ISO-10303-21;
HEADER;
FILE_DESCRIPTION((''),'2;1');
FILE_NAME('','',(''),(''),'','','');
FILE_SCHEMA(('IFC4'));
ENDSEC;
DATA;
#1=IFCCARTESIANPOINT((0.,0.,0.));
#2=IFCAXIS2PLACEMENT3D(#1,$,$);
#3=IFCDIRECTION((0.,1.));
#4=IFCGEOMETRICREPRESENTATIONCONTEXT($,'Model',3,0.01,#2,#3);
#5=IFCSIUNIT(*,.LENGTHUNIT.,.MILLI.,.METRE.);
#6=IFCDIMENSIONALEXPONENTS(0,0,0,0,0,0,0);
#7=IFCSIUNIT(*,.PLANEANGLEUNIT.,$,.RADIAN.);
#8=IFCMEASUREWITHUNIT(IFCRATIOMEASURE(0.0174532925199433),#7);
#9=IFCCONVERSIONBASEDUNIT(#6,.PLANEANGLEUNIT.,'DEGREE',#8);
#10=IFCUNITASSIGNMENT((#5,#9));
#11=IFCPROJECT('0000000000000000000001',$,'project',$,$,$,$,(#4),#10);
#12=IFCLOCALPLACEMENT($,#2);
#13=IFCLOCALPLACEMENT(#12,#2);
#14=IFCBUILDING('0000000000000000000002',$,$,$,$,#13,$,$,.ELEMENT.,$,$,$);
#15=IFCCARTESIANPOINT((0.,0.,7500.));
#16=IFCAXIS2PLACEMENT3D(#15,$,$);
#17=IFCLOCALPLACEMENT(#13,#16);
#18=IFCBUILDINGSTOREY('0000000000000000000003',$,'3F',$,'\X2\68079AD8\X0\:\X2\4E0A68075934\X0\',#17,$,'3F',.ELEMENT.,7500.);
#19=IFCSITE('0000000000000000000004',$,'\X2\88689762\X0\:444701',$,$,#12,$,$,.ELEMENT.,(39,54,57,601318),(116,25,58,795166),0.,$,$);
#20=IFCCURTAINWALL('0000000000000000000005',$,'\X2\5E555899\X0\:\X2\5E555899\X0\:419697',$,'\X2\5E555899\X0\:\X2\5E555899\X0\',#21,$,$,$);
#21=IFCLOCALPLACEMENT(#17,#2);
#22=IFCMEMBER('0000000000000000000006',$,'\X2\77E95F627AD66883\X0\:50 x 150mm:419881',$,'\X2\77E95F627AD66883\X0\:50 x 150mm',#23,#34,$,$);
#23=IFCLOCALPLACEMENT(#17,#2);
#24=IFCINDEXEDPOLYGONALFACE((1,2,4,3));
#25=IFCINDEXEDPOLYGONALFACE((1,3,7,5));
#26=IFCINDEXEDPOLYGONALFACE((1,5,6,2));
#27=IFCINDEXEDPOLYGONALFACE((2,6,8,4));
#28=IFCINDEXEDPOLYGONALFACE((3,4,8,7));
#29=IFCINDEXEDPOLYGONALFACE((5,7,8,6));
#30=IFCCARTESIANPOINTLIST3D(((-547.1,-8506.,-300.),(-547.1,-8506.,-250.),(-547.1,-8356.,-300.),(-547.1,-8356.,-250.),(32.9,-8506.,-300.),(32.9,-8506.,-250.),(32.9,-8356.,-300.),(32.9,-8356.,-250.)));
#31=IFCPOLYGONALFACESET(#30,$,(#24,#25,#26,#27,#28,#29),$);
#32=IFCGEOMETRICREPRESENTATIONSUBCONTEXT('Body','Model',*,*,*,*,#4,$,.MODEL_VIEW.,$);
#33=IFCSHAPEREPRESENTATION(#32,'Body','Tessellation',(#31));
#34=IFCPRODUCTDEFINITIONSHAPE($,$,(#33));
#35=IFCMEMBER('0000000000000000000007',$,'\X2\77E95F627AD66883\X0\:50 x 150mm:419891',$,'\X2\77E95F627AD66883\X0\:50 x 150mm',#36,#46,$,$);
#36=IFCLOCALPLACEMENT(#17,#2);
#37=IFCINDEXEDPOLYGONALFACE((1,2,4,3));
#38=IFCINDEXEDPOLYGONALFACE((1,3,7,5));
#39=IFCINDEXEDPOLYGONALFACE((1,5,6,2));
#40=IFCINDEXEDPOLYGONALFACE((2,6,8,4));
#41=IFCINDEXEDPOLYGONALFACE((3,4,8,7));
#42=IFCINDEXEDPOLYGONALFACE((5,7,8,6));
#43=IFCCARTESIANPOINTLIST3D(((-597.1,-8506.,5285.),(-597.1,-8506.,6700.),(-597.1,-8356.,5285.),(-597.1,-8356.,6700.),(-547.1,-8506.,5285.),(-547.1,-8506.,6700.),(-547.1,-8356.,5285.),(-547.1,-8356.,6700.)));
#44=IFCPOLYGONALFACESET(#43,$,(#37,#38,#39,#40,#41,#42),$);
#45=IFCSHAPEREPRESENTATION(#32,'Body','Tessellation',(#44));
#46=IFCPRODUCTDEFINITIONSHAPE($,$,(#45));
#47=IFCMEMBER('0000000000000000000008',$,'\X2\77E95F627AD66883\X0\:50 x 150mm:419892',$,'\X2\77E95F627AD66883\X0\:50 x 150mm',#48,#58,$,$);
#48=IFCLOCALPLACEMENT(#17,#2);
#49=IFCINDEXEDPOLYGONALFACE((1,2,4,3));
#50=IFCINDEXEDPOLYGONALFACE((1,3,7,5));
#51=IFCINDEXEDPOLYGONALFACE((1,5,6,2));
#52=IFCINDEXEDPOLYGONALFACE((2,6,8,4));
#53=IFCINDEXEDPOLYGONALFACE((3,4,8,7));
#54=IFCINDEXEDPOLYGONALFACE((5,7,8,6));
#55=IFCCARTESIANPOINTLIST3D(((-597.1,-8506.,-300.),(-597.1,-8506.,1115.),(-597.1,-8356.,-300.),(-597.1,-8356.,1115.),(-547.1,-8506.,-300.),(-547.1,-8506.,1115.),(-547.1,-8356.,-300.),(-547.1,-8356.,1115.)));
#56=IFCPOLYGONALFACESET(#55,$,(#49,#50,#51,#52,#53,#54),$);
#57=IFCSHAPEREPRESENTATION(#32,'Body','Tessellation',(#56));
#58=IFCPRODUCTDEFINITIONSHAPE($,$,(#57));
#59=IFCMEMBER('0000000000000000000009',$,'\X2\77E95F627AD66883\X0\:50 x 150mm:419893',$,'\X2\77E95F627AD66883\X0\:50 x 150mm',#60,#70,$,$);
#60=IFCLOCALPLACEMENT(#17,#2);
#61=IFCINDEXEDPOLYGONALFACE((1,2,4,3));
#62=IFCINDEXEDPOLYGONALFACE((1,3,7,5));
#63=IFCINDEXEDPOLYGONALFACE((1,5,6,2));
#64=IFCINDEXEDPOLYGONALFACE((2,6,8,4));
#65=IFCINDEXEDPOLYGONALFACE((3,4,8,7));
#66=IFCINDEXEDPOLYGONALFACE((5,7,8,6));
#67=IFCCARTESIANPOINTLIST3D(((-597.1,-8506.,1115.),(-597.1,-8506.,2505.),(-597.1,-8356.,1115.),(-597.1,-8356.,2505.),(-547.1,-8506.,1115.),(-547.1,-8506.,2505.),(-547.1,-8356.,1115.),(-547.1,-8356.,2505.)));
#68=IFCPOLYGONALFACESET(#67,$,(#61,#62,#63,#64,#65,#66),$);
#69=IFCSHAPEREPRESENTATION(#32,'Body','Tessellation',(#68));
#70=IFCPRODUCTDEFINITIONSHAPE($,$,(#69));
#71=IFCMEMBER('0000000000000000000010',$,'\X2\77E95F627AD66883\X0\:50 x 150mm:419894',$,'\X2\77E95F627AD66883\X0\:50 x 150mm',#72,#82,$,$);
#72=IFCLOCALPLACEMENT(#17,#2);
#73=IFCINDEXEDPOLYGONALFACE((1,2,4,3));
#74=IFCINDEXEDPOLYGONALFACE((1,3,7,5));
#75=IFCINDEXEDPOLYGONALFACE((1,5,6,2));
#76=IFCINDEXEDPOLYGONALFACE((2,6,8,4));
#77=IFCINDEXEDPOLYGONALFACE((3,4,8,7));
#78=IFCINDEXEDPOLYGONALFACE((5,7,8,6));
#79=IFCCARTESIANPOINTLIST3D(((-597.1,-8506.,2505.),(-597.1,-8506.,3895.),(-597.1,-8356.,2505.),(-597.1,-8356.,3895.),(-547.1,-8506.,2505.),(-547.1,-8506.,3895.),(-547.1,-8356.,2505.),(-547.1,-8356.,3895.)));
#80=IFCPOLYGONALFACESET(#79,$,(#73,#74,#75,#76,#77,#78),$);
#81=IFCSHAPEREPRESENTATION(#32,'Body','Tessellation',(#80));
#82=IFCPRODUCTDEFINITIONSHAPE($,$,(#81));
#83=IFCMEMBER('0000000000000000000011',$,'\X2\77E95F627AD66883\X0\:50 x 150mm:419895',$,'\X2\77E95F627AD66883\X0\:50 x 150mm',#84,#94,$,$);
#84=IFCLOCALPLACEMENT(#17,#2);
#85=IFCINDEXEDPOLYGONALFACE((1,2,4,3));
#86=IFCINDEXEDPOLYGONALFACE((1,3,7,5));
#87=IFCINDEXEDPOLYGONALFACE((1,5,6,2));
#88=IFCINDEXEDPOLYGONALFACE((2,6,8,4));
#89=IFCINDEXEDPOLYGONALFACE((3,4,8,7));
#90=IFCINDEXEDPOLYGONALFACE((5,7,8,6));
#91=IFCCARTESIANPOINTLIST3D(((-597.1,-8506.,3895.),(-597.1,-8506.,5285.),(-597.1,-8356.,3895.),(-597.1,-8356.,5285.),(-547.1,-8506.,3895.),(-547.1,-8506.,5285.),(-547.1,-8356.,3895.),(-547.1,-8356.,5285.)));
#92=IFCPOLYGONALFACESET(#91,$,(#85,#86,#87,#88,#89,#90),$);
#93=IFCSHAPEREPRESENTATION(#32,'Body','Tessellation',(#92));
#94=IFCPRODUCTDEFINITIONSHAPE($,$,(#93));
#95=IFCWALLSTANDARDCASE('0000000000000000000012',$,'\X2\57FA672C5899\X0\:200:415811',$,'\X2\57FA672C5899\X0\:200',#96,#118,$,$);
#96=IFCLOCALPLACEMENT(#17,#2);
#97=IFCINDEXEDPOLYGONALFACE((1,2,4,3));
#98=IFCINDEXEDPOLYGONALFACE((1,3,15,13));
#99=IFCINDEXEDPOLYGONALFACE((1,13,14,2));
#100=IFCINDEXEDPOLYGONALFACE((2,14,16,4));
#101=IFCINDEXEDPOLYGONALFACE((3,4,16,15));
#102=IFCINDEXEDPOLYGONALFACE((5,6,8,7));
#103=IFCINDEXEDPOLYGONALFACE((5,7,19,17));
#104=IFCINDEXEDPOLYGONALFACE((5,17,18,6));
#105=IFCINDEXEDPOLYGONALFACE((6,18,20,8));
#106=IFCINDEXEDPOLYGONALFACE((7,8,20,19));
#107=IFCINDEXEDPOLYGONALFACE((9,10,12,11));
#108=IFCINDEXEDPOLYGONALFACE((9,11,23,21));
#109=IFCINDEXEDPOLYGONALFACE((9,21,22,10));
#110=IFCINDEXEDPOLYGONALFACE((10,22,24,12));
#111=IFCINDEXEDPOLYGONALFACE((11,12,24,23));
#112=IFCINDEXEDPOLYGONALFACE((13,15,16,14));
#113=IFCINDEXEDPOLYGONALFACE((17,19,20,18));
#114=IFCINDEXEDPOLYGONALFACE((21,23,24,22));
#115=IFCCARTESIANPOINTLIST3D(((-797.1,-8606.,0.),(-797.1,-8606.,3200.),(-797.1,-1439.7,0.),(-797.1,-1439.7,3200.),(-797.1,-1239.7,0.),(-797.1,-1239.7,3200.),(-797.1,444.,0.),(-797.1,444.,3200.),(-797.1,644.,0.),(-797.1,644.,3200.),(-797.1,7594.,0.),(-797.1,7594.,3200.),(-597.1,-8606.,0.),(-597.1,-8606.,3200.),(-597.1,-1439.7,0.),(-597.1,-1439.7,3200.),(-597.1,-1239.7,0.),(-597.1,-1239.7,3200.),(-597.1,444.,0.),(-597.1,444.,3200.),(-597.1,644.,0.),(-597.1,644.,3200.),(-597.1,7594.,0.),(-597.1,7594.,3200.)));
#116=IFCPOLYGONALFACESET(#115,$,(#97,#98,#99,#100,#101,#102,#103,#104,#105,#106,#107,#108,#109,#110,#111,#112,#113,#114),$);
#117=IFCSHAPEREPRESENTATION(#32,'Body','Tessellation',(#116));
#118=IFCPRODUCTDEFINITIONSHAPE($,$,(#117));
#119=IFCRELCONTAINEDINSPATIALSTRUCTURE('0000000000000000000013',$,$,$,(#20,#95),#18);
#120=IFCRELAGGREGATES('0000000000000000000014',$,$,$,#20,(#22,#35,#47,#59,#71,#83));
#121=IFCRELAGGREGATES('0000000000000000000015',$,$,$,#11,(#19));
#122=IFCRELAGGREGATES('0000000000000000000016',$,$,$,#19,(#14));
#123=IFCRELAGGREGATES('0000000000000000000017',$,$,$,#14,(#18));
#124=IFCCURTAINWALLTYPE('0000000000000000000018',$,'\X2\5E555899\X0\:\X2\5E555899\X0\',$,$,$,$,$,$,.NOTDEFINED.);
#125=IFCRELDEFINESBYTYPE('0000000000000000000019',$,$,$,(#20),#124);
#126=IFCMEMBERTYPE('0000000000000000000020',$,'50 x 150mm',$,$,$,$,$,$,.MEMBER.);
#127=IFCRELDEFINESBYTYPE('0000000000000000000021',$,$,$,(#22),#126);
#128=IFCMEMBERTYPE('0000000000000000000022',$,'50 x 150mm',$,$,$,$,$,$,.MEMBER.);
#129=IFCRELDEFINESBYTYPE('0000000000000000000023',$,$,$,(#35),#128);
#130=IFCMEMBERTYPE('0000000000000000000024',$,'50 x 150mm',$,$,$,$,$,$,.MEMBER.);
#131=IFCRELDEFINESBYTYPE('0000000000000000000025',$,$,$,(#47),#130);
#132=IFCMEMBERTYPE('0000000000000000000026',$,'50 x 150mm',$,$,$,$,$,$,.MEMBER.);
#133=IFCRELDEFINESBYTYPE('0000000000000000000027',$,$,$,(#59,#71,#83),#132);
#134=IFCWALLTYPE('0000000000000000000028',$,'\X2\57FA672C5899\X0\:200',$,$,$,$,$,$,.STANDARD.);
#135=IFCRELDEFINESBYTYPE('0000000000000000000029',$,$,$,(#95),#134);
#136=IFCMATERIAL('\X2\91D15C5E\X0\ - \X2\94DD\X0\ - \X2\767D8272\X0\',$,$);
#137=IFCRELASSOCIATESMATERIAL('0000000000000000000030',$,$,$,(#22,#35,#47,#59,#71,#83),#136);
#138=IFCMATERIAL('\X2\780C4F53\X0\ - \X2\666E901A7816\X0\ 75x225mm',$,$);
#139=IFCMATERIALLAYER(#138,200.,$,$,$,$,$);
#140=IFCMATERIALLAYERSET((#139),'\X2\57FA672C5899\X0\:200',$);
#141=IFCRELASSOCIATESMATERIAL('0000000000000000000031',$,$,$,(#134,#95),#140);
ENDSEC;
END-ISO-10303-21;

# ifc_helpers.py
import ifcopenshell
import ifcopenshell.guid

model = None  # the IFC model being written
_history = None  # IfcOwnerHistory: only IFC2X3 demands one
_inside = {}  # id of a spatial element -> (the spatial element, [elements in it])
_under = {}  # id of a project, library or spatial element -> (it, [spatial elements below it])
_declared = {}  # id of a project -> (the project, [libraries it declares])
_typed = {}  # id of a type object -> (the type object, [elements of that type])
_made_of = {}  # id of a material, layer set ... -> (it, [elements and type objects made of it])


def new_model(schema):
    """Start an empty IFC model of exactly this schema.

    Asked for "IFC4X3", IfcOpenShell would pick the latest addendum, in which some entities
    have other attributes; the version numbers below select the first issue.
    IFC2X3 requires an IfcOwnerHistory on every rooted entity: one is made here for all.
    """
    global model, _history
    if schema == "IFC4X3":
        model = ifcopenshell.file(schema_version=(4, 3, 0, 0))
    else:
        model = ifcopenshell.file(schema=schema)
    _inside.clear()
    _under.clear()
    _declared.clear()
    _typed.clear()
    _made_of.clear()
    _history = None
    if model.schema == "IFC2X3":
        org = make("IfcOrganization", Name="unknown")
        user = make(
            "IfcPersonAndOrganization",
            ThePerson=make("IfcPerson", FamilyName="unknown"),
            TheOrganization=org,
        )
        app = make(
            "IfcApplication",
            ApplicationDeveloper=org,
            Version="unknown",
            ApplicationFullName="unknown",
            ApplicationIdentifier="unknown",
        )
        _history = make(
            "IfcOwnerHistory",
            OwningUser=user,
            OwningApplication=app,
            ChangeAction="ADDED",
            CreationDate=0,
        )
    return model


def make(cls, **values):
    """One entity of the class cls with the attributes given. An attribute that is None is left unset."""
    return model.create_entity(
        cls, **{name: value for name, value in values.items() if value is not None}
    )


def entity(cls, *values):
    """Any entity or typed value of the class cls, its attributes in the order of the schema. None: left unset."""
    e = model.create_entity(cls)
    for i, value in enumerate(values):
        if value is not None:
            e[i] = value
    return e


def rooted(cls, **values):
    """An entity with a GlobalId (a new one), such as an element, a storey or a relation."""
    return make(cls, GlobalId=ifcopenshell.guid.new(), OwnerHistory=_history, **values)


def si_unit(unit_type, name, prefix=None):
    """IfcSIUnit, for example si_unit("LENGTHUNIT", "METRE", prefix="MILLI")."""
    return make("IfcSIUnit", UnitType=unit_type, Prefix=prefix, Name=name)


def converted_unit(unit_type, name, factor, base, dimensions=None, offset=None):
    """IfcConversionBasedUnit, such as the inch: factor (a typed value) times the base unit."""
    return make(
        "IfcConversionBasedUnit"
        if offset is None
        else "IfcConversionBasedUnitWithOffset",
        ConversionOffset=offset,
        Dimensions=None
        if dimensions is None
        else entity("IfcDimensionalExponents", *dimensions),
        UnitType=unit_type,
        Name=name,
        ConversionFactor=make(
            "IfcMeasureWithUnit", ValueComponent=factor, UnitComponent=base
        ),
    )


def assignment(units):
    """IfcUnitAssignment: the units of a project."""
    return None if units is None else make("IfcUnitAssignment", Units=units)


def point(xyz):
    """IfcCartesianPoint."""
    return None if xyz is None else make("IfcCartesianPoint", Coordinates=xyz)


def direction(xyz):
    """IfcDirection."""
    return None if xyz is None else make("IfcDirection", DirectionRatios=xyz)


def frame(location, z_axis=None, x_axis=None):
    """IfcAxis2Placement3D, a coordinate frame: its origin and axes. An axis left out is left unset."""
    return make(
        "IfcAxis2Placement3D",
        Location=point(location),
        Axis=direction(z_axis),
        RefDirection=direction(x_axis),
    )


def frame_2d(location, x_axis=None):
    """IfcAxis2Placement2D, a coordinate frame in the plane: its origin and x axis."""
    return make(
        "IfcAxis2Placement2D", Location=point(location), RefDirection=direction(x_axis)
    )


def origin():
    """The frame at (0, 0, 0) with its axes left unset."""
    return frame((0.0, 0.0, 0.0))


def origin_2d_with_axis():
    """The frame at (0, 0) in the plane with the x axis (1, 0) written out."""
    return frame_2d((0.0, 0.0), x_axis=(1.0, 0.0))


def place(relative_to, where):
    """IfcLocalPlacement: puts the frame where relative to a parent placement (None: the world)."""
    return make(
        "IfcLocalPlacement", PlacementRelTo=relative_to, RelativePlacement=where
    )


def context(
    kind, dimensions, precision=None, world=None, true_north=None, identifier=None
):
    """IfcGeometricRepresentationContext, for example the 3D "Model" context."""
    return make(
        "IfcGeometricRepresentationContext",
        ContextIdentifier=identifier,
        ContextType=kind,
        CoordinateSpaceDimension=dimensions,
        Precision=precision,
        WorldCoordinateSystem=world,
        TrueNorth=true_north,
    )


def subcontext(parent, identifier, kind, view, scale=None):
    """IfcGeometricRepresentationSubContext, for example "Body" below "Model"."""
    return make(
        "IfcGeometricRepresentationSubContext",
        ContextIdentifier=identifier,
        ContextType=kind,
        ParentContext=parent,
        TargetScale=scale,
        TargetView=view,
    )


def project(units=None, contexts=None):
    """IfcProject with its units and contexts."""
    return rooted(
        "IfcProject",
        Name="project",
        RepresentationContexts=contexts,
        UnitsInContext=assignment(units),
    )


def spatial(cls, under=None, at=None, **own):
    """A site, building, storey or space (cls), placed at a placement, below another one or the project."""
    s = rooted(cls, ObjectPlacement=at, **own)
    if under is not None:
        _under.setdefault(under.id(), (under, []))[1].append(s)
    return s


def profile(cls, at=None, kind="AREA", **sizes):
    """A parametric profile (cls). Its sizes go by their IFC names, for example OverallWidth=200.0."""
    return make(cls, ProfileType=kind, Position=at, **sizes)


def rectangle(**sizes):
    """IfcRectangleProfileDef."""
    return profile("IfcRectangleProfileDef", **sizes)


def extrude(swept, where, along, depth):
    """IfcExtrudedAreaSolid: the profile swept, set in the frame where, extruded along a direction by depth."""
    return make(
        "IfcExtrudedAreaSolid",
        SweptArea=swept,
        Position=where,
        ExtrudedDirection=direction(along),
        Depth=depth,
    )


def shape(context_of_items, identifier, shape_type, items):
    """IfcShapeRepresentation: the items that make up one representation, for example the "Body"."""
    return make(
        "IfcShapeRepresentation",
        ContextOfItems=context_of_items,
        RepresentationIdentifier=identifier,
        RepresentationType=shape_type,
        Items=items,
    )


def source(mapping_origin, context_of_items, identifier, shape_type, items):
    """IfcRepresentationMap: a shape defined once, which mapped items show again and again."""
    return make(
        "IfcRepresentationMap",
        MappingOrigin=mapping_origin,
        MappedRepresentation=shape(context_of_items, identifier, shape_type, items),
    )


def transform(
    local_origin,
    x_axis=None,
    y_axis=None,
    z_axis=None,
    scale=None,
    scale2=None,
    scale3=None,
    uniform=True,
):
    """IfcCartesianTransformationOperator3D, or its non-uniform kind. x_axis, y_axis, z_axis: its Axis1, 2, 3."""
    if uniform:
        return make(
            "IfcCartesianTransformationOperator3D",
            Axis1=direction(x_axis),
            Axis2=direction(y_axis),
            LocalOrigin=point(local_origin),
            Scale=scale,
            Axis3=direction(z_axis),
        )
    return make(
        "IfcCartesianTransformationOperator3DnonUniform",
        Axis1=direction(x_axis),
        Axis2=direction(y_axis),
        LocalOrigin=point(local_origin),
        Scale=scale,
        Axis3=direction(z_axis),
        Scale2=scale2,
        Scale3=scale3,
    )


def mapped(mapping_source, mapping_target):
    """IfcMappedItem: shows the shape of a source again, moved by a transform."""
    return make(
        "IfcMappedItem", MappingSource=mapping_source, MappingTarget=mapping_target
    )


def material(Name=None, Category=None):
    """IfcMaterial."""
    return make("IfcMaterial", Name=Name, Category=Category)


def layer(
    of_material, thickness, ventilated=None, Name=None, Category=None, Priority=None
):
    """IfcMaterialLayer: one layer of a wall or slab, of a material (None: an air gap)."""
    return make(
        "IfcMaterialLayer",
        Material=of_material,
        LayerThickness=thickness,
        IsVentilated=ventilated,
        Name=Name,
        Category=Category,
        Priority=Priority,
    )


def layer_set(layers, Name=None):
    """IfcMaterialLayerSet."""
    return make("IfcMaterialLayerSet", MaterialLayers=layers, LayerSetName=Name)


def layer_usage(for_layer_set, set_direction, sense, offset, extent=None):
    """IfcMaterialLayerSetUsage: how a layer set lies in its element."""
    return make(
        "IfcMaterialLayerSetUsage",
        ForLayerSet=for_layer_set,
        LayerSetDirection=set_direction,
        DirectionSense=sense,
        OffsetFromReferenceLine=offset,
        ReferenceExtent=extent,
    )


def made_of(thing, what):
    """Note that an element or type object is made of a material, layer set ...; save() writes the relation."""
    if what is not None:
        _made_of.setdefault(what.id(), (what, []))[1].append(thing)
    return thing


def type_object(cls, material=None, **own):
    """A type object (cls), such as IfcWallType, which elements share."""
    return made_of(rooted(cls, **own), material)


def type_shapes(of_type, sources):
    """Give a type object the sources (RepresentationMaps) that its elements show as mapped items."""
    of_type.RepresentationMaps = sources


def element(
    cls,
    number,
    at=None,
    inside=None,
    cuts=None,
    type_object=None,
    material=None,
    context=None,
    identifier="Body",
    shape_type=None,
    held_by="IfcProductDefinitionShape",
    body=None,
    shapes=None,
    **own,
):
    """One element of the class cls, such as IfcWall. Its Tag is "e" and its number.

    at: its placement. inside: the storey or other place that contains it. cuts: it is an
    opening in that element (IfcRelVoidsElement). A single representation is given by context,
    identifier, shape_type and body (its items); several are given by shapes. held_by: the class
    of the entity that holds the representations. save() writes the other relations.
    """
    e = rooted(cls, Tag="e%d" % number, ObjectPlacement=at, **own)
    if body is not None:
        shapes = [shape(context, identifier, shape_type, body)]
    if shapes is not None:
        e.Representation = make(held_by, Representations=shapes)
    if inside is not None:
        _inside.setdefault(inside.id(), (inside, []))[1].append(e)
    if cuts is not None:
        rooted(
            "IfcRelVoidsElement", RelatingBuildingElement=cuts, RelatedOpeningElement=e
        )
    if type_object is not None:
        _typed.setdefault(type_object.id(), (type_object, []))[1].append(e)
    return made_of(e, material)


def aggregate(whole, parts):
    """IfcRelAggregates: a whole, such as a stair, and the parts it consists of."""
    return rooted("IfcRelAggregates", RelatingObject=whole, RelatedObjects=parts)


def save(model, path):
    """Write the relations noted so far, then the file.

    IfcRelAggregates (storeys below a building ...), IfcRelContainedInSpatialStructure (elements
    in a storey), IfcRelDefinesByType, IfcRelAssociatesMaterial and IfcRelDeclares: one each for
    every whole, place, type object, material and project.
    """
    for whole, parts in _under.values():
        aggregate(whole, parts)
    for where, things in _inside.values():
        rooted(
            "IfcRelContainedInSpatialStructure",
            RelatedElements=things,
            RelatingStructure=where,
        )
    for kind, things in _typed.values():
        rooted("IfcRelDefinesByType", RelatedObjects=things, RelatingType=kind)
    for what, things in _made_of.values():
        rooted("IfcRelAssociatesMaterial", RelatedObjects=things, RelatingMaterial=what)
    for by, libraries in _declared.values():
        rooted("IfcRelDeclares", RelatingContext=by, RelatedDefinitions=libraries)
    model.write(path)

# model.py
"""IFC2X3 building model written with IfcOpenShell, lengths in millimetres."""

from ifc_helpers import new_model, entity, si_unit, converted_unit, direction, frame, frame_2d, origin, origin_2d_with_axis, place, context, subcontext, project, spatial, rectangle, extrude, source, transform, mapped, material, layer, layer_set, layer_usage, type_object, type_shapes, element, aggregate, save


model = new_model("IFC2X3")

# Units and contexts
model_context = context("Model", 3, precision=0.01, world=origin(), true_north=direction((0.0, 1.0)))
body_context = subcontext(model_context, "Body", "Model", "MODEL_VIEW")
ifc_project = project(units=[si_unit("LENGTHUNIT", "METRE", prefix="MILLI"), converted_unit("PLANEANGLEUNIT", "DEGREE", entity("IfcRatioMeasure", 0.0174532925199433), si_unit("PLANEANGLEUNIT", "RADIAN"), dimensions=[0, 0, 0, 0, 0, 0, 0])], contexts=[model_context])

# Site, building, storey
site_placement = place(None, origin())
site = spatial("IfcSite", under=ifc_project, at=site_placement, Name="表面:444701", CompositionType="ELEMENT", RefLatitude=(39, 54, 57, 601318), RefLongitude=(116, 25, 58, 795166), RefElevation=0.0)
building_placement = place(site_placement, origin())
building = spatial("IfcBuilding", under=site, at=building_placement, CompositionType="ELEMENT")
storey_placement = place(building_placement, frame((0.0, 0.0, 7500.0)))
storey = spatial("IfcBuildingStorey", under=building, at=storey_placement, Name="3F", ObjectType="标高:上标头", LongName="3F", CompositionType="ELEMENT", Elevation=7500.0)

# Curtain wall, members
curtain_wall_type = type_object("IfcCurtainWallType", Name="幕墙:幕墙", PredefinedType="NOTDEFINED")
curtain_wall_placement = place(storey_placement, frame((0.0, 0.0, -7500.0)))
curtain_wall = element("IfcCurtainWall", 1, at=curtain_wall_placement, inside=storey, type_object=curtain_wall_type, Name="幕墙:幕墙:419697", ObjectType="幕墙:幕墙")
ifc_material_1 = material(Name="金属 - 铝 - 白色")
member_type_1 = type_object("IfcMemberType", Name="50 x 150mm", PredefinedType="MEMBER")
shared_shape_1 = source(origin(), body_context, "Body", "SweptSolid", [
    extrude(rectangle(XDim=150.0, YDim=50.0, at=origin_2d_with_axis()), frame((-25.0, 0.0, -580.0), z_axis=(0.0, 0.0, 1.0), x_axis=(0.0, -1.0, 0.0)), (0.0, 0.0, 1.0), 580.0),
])
type_shapes(member_type_1, [shared_shape_1])
member_1_placement = place(storey_placement, frame((-547.1, -8431.0, -300.0), z_axis=(-1.0, 0.0, 0.0), x_axis=(0.0, 0.0, -1.0)))
member_1 = element("IfcMember", 2, at=member_1_placement, type_object=member_type_1, material=ifc_material_1, Name="矩形竖梃:50 x 150mm:419881", ObjectType="矩形竖梃:50 x 150mm", context=body_context, shape_type="MappedRepresentation", body=[
    mapped(shared_shape_1, transform((0.0, 0.0, 0.0), scale=1.0)),
])
member_type_2 = type_object("IfcMemberType", Name="50 x 150mm", PredefinedType="MEMBER")
shared_shape_2 = source(origin(), body_context, "Body", "SweptSolid", [
    extrude(rectangle(XDim=150.0, YDim=50.0, at=origin_2d_with_axis()), frame((-25.0, 0.0, -1415.0), z_axis=(0.0, 0.0, 1.0), x_axis=(0.0, -1.0, 0.0)), (0.0, 0.0, 1.0), 1415.0),
])
type_shapes(member_type_2, [shared_shape_2])
member_2_placement = place(storey_placement, frame((-597.1, -8431.0, 6700.0), z_axis=(0.0, 0.0, 1.0), x_axis=(-1.0, 0.0, 0.0)))
member_2 = element("IfcMember", 3, at=member_2_placement, type_object=member_type_2, material=ifc_material_1, Name="矩形竖梃:50 x 150mm:419891", ObjectType="矩形竖梃:50 x 150mm", context=body_context, shape_type="MappedRepresentation", body=[
    mapped(shared_shape_2, transform((0.0, 0.0, 0.0), scale=1.0)),
])
member_type_3 = type_object("IfcMemberType", Name="50 x 150mm", PredefinedType="MEMBER")
shared_shape_3 = source(origin(), body_context, "Body", "SweptSolid", [
    extrude(rectangle(XDim=150.0, YDim=50.0, at=origin_2d_with_axis()), frame((-25.0, 0.0, -1415.0), z_axis=(0.0, 0.0, 1.0), x_axis=(0.0, -1.0, 0.0)), (0.0, 0.0, 1.0), 1415.0),
])
type_shapes(member_type_3, [shared_shape_3])
member_3_placement = place(storey_placement, frame((-597.1, -8431.0, 1115.0), z_axis=(0.0, 0.0, 1.0), x_axis=(-1.0, 0.0, 0.0)))
member_3 = element("IfcMember", 4, at=member_3_placement, type_object=member_type_3, material=ifc_material_1, Name="矩形竖梃:50 x 150mm:419892", ObjectType="矩形竖梃:50 x 150mm", context=body_context, shape_type="MappedRepresentation", body=[
    mapped(shared_shape_3, transform((0.0, 0.0, 0.0), scale=1.0)),
])
member_type_4 = type_object("IfcMemberType", Name="50 x 150mm", PredefinedType="MEMBER")
shared_shape_4 = source(origin(), body_context, "Body", "SweptSolid", [
    extrude(rectangle(XDim=150.0, YDim=50.0, at=origin_2d_with_axis()), frame((-25.0, 0.0, -1390.0), z_axis=(0.0, 0.0, 1.0), x_axis=(0.0, -1.0, 0.0)), (0.0, 0.0, 1.0), 1390.0),
])
type_shapes(member_type_4, [shared_shape_4])
member_4_placement = place(storey_placement, frame((-597.1, -8431.0, 2505.0), z_axis=(0.0, 0.0, 1.0), x_axis=(-1.0, 0.0, 0.0)))
member_4 = element("IfcMember", 5, at=member_4_placement, type_object=member_type_4, material=ifc_material_1, Name="矩形竖梃:50 x 150mm:419893", ObjectType="矩形竖梃:50 x 150mm", context=body_context, shape_type="MappedRepresentation", body=[
    mapped(shared_shape_4, transform((0.0, 0.0, 0.0), scale=1.0)),
])
member_5_placement = place(storey_placement, frame((-597.1, -8431.0, 3895.0), z_axis=(0.0, 0.0, 1.0), x_axis=(-1.0, 0.0, 0.0)))
member_5 = element("IfcMember", 6, at=member_5_placement, type_object=member_type_4, material=ifc_material_1, Name="矩形竖梃:50 x 150mm:419894", ObjectType="矩形竖梃:50 x 150mm", context=body_context, shape_type="MappedRepresentation", body=[
    mapped(shared_shape_4, transform((0.0, 0.0, 0.0), scale=1.0)),
])
member_6_placement = place(storey_placement, frame((-597.1, -8431.0, 5285.0), z_axis=(0.0, 0.0, 1.0), x_axis=(-1.0, 0.0, 0.0)))
member_6 = element("IfcMember", 7, at=member_6_placement, type_object=member_type_4, material=ifc_material_1, Name="矩形竖梃:50 x 150mm:419895", ObjectType="矩形竖梃:50 x 150mm", context=body_context, shape_type="MappedRepresentation", body=[
    mapped(shared_shape_4, transform((0.0, 0.0, 0.0), scale=1.0)),
])
aggregate(curtain_wall, [member_1, member_2, member_3, member_4, member_5, member_6])

# Shared definitions
ifc_material_2 = material(Name="砌体 - 普通砖 75x225mm")

# Wall, openings
ifc_layer_1 = layer(ifc_material_2, 200.0)
ifc_layer_set_1 = layer_set([ifc_layer_1], Name="基本墙:200")
ifc_layer_usage_1 = layer_usage(ifc_layer_set_1, "AXIS2", "NEGATIVE", 100.0)
wall_type_1 = type_object("IfcWallType", Name="基本墙:200", PredefinedType="STANDARD", material=ifc_layer_set_1)
wall_1_placement = place(storey_placement, frame((-697.1, -8606.0, 0.0), z_axis=(0.0, 0.0, 1.0), x_axis=(0.0, 1.0, 0.0)))
wall_1 = element("IfcWallStandardCase", 8, at=wall_1_placement, inside=storey, type_object=wall_type_1, material=ifc_layer_usage_1, Name="基本墙:200:415811", ObjectType="基本墙:200", context=body_context, shape_type="SweptSolid", body=[
    extrude(rectangle(XDim=16200.0, YDim=200.0, at=frame_2d((8100.0, 0.0), x_axis=(-1.0, 0.0))), origin(), (0.0, 0.0, 1.0), 3200.0),
])
opening_1_placement = place(storey_placement, frame((-697.1, -8606.0, 0.0), z_axis=(0.0, 0.0, 1.0), x_axis=(0.0, 1.0, 0.0)))
element("IfcOpeningElement", 9, at=opening_1_placement, cuts=wall_1, ObjectType="Opening", context=body_context, shape_type="SweptSolid", body=[
    extrude(rectangle(XDim=3200.0, YDim=200.0, at=origin_2d_with_axis()), frame((9050.0, 0.0, 1600.0), z_axis=(1.0, 0.0, 0.0), x_axis=(0.0, 0.0, -1.0)), (0.0, 0.0, 1.0), 200.0),
])
opening_2_placement = place(storey_placement, frame((-697.1, -8606.0, 0.0), z_axis=(0.0, 0.0, 1.0), x_axis=(0.0, 1.0, 0.0)))
element("IfcOpeningElement", 10, at=opening_2_placement, cuts=wall_1, ObjectType="Opening", context=body_context, shape_type="SweptSolid", body=[
    extrude(rectangle(XDim=3200.0, YDim=200.0, at=frame_2d((0.0, 0.0), x_axis=(1.0, 0.0))), frame((7166.3, 0.0, 1600.0), z_axis=(1.0, 0.0, 0.0), x_axis=(0.0, 0.0, -1.0)), (0.0, 0.0, 1.0), 200.0),
])

save(model, "model.ifc")
